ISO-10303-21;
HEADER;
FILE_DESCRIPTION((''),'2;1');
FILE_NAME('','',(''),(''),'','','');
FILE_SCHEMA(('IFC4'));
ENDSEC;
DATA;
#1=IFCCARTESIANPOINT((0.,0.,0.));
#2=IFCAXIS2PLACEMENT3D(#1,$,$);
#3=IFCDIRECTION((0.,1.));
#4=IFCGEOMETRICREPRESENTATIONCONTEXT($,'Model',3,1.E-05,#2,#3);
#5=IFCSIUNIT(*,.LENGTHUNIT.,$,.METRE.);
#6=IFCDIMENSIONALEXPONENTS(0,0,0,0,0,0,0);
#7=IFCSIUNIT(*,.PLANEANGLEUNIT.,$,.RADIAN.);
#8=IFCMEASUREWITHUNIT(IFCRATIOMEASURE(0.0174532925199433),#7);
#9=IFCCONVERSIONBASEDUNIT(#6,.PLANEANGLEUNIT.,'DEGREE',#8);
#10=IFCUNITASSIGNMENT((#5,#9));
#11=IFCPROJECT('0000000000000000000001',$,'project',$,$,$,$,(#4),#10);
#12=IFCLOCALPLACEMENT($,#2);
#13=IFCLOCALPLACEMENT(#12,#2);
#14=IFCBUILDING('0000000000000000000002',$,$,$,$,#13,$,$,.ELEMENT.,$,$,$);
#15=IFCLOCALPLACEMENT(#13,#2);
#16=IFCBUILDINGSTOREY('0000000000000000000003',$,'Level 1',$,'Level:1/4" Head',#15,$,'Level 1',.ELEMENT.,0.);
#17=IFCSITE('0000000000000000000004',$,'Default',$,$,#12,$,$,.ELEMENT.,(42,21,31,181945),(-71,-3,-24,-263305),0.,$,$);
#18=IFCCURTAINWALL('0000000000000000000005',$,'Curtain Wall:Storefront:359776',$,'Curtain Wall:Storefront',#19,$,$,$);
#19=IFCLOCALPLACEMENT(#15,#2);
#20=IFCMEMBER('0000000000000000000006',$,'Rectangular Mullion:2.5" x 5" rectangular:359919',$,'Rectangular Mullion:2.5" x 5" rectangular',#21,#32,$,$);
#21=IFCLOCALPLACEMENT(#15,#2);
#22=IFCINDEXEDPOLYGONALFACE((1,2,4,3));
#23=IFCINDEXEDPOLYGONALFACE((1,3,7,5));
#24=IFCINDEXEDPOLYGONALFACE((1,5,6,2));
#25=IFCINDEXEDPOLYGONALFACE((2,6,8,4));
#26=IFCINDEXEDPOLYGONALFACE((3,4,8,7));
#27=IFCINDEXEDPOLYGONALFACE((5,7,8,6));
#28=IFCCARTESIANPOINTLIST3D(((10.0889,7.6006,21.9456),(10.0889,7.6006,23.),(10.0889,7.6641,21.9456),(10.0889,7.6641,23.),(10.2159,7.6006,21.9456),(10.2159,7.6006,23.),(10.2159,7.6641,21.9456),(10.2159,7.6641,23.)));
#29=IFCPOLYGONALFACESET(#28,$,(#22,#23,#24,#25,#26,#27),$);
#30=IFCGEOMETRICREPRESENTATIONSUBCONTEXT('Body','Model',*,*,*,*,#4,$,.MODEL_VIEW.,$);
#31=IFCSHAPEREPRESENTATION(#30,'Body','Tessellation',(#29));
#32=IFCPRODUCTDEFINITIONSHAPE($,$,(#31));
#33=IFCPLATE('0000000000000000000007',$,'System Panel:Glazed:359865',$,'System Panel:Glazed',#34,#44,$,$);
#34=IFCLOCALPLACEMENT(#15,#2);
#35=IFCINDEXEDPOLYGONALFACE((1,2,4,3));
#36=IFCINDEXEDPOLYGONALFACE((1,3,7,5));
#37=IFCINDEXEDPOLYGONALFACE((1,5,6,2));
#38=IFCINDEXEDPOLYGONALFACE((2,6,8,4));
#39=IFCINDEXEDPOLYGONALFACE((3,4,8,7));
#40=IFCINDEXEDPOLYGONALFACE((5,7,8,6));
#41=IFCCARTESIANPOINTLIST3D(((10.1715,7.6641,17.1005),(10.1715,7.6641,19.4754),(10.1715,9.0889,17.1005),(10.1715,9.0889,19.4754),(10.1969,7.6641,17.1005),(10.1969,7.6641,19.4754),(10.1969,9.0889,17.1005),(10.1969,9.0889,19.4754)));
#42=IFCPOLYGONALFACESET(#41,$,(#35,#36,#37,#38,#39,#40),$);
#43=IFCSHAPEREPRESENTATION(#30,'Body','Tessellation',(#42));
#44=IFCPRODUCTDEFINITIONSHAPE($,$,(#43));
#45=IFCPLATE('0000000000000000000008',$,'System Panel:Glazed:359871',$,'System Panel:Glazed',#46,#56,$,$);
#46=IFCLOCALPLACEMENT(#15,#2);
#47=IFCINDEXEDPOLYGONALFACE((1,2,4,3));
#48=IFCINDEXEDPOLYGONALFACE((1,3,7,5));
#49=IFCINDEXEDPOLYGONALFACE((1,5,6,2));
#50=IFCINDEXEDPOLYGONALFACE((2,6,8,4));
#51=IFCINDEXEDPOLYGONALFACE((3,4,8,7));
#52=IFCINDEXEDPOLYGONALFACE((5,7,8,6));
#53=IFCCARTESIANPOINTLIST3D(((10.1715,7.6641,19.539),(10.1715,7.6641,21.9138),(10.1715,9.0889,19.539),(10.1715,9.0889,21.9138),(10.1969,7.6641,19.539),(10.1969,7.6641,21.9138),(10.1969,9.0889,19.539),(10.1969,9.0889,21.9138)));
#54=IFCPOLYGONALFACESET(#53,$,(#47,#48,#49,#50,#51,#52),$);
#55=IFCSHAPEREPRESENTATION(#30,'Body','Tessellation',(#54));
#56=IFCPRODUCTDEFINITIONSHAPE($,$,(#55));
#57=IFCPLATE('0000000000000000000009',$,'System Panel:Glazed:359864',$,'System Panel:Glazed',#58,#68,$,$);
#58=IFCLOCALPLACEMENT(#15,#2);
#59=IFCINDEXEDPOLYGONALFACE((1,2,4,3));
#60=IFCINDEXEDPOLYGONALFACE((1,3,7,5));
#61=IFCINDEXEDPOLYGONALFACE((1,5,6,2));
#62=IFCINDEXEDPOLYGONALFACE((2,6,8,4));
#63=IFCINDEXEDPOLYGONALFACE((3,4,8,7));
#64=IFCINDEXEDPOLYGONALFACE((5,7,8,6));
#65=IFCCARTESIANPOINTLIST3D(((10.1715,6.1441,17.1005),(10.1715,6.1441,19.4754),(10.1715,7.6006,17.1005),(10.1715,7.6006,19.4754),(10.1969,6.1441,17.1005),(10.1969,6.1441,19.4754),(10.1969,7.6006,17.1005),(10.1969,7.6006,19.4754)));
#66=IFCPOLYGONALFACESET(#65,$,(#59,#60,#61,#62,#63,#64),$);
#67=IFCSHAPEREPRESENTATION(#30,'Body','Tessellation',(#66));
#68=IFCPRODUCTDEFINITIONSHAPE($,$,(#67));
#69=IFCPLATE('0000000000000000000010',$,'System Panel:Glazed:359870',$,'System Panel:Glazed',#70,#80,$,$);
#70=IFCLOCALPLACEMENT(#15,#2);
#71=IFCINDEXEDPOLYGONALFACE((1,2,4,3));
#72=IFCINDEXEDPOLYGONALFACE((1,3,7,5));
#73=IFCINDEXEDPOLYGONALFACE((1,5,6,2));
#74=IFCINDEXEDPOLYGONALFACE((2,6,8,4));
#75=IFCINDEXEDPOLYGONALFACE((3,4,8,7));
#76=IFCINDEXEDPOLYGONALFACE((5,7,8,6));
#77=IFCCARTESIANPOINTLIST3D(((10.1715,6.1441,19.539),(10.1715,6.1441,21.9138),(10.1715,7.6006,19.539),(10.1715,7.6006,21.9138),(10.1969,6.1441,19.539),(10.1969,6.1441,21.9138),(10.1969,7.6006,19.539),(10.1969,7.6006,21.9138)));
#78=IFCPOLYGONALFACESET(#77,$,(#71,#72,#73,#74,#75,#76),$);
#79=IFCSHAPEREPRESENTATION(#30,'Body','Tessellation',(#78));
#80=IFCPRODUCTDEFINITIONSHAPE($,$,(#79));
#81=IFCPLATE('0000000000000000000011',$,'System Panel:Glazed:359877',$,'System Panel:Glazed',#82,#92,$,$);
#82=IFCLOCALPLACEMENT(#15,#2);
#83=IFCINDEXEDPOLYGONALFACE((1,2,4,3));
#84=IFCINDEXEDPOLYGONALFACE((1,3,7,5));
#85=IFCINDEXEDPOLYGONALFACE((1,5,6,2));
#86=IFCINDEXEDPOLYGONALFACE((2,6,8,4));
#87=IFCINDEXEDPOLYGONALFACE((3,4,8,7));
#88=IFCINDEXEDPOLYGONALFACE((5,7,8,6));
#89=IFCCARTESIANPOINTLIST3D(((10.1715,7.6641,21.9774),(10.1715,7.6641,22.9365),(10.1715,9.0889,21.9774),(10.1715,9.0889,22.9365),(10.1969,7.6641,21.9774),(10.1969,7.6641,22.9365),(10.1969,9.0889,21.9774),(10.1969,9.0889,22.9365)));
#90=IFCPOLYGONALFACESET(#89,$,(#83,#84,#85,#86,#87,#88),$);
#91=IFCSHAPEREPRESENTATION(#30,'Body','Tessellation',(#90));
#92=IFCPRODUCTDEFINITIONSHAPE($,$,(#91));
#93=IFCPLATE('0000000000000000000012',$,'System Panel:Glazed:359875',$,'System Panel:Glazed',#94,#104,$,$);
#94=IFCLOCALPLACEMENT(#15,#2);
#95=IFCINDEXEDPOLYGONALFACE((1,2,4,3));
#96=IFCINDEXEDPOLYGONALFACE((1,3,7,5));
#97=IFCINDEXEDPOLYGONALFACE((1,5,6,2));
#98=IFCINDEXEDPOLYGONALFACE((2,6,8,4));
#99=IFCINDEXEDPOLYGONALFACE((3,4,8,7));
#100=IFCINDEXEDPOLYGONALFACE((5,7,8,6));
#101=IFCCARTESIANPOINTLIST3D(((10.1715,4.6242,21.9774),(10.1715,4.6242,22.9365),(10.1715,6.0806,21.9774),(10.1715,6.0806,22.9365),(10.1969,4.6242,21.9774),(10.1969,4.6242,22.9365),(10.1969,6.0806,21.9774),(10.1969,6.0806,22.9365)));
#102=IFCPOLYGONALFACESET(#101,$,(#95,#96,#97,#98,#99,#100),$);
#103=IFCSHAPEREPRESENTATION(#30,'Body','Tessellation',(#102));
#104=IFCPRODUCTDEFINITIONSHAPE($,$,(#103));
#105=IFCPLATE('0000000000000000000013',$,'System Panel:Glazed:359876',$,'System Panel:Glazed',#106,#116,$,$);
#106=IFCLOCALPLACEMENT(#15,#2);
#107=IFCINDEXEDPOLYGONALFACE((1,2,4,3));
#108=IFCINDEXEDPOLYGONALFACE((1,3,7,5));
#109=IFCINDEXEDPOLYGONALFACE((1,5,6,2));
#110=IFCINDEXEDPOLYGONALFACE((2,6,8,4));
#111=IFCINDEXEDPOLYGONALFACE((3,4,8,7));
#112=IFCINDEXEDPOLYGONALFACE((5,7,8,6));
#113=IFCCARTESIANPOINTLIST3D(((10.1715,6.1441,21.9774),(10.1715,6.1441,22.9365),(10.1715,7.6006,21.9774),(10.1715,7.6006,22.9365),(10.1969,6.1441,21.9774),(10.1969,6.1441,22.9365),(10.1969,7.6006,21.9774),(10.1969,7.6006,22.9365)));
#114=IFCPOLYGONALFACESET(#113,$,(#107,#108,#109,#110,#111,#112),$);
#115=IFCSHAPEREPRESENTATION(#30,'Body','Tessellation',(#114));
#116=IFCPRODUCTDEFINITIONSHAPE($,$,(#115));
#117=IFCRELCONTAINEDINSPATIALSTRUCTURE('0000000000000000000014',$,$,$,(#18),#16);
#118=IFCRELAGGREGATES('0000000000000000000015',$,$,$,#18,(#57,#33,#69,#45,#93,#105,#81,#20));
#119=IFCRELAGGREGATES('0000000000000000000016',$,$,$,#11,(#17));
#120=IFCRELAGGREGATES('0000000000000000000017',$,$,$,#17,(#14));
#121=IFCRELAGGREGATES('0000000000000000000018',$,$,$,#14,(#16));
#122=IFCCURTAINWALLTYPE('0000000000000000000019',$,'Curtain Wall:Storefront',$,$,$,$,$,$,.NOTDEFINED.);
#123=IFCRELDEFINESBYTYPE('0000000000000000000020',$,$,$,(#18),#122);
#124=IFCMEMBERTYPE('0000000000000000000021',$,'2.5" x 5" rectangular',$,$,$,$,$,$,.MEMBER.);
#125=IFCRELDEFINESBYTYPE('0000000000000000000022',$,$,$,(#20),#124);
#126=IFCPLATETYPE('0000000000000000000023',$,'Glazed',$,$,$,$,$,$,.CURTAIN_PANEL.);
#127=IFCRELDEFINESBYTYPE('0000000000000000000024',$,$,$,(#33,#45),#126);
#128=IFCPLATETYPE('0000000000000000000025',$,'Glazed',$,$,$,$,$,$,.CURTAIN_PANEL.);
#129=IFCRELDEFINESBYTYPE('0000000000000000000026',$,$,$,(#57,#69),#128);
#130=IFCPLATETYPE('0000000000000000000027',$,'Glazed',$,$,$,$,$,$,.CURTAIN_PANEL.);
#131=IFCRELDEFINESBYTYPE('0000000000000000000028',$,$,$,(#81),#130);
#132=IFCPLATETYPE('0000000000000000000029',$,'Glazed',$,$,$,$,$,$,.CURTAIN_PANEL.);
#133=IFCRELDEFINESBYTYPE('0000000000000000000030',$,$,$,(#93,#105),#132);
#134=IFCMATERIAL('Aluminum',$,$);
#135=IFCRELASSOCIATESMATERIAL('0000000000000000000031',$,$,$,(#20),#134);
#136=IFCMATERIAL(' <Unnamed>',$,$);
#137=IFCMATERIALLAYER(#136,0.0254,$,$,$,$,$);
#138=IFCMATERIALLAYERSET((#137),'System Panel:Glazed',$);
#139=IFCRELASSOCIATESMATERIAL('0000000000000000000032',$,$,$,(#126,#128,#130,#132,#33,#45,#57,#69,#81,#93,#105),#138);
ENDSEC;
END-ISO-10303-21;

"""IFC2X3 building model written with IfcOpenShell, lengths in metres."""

from ifc_helpers import new_model, entity, si_unit, converted_unit, direction, frame, frame_2d, origin, origin_2d_with_axis, place, context, subcontext, project, spatial, rectangle, extrude, source, transform, mapped, material, layer, layer_set, layer_usage, type_object, type_shapes, element, aggregate, save


model = new_model("IFC2X3")

# Units and contexts
model_context = context("Model", 3, precision=1e-05, world=origin(), true_north=direction((0.0, 1.0)))
body_context = subcontext(model_context, "Body", "Model", "MODEL_VIEW")
ifc_project = project(units=[si_unit("LENGTHUNIT", "METRE"), converted_unit("PLANEANGLEUNIT", "DEGREE", entity("IfcRatioMeasure", 0.0174532925199433), si_unit("PLANEANGLEUNIT", "RADIAN"), dimensions=[0, 0, 0, 0, 0, 0, 0])], contexts=[model_context])

# Site, building, storey
site_placement = place(None, origin())
site = spatial("IfcSite", under=ifc_project, at=site_placement, Name="Default", CompositionType="ELEMENT", RefLatitude=(42, 21, 31, 181945), RefLongitude=(-71, -3, -24, -263305), RefElevation=0.0)
building_placement = place(site_placement, origin())
building = spatial("IfcBuilding", under=site, at=building_placement, CompositionType="ELEMENT")
storey_placement = place(building_placement, origin())
storey = spatial("IfcBuildingStorey", under=building, at=storey_placement, Name="Level 1", ObjectType="Level:1/4\" Head", LongName="Level 1", CompositionType="ELEMENT", Elevation=0.0)

# Curtain wall, member, plates
curtain_wall_type = type_object("IfcCurtainWallType", Name="Curtain Wall:Storefront", PredefinedType="NOTDEFINED")
curtain_wall_placement = place(storey_placement, origin())
curtain_wall = element("IfcCurtainWall", 1, at=curtain_wall_placement, inside=storey, type_object=curtain_wall_type, Name="Curtain Wall:Storefront:359776", ObjectType="Curtain Wall:Storefront")
ifc_material_1 = material(Name="Aluminum")
member_type_1 = type_object("IfcMemberType", Name="2.5\" x 5\" rectangular", PredefinedType="MEMBER")
shared_shape_1 = source(origin(), body_context, "Body", "SweptSolid", [
    extrude(rectangle(XDim=0.127, YDim=0.0635, at=origin_2d_with_axis()), frame((0.0, 0.0, -1.0544), z_axis=(0.0, 0.0, 1.0), x_axis=(0.0, -1.0, 0.0)), (0.0, 0.0, 1.0), 1.0544),
])
type_shapes(member_type_1, [shared_shape_1])
member_1_placement = place(storey_placement, frame((10.1524, 7.6324, 21.9456), z_axis=(0.0, 0.0, -1.0), x_axis=(0.0, 1.0, 0.0)))
member_1 = element("IfcMember", 2, at=member_1_placement, type_object=member_type_1, material=ifc_material_1, Name="Rectangular Mullion:2.5\" x 5\" rectangular:359919", ObjectType="Rectangular Mullion:2.5\" x 5\" rectangular", context=body_context, shape_type="MappedRepresentation", body=[
    mapped(shared_shape_1, transform((0.0, 0.0, 0.0), scale=1.0)),
])
ifc_material_2 = material(Name=" <Unnamed>")
ifc_layer = layer(ifc_material_2, 0.0254)
ifc_layer_set = layer_set([ifc_layer], Name="System Panel:Glazed")
ifc_layer_usage_1 = layer_usage(ifc_layer_set, "AXIS3", "POSITIVE", 0.1042)
plate_type_1 = type_object("IfcPlateType", Name="Glazed", PredefinedType="CURTAIN_PANEL", material=ifc_layer_set)
shared_shape_2 = source(origin(), body_context, "Body", "SweptSolid", [
    extrude(rectangle(XDim=0.0254, YDim=1.4248, at=frame_2d((0.0, 0.0), x_axis=(1.0, 0.0))), frame((0.7124, 0.0127, 0.0), z_axis=(0.0, 0.0, 1.0), x_axis=(0.0, 1.0, 0.0)), (0.0, 0.0, 1.0), 2.3749),
])
type_shapes(plate_type_1, [shared_shape_2])
plate_1_placement = place(curtain_wall_placement, frame((10.1969, 7.6641, 17.1005), z_axis=(0.0, 0.0, 1.0), x_axis=(0.0, 1.0, 0.0)))
plate_1 = element("IfcPlate", 3, at=plate_1_placement, type_object=plate_type_1, material=ifc_layer_usage_1, Name="System Panel:Glazed:359865", ObjectType="System Panel:Glazed", context=body_context, shape_type="MappedRepresentation", body=[
    mapped(shared_shape_2, transform((0.0, 0.0, 0.0), scale=1.0)),
])
ifc_layer_usage_2 = layer_usage(ifc_layer_set, "AXIS3", "POSITIVE", 0.1042)
plate_2_placement = place(curtain_wall_placement, frame((10.1969, 7.6641, 19.5389), z_axis=(0.0, 0.0, 1.0), x_axis=(0.0, 1.0, 0.0)))
plate_2 = element("IfcPlate", 4, at=plate_2_placement, type_object=plate_type_1, material=ifc_layer_usage_2, Name="System Panel:Glazed:359871", ObjectType="System Panel:Glazed", context=body_context, shape_type="MappedRepresentation", body=[
    mapped(shared_shape_2, transform((0.0, 0.0, 0.0), scale=1.0)),
])
ifc_layer_usage_3 = layer_usage(ifc_layer_set, "AXIS3", "POSITIVE", 0.1042)
plate_type_2 = type_object("IfcPlateType", Name="Glazed", PredefinedType="CURTAIN_PANEL", material=ifc_layer_set)
shared_shape_3 = source(origin(), body_context, "Body", "SweptSolid", [
    extrude(rectangle(XDim=0.0254, YDim=1.4565, at=origin_2d_with_axis()), frame((0.7282, 0.0127, 0.0), z_axis=(0.0, 0.0, 1.0), x_axis=(0.0, 1.0, 0.0)), (0.0, 0.0, 1.0), 2.3749),
])
type_shapes(plate_type_2, [shared_shape_3])
plate_3_placement = place(curtain_wall_placement, frame((10.1969, 6.1441, 17.1005), z_axis=(0.0, 0.0, 1.0), x_axis=(0.0, 1.0, 0.0)))
plate_3 = element("IfcPlate", 5, at=plate_3_placement, type_object=plate_type_2, material=ifc_layer_usage_3, Name="System Panel:Glazed:359864", ObjectType="System Panel:Glazed", context=body_context, shape_type="MappedRepresentation", body=[
    mapped(shared_shape_3, transform((0.0, 0.0, 0.0), scale=1.0)),
])
ifc_layer_usage_4 = layer_usage(ifc_layer_set, "AXIS3", "POSITIVE", 0.1042)
plate_4_placement = place(curtain_wall_placement, frame((10.1969, 6.1441, 19.5389), z_axis=(0.0, 0.0, 1.0), x_axis=(0.0, 1.0, 0.0)))
plate_4 = element("IfcPlate", 6, at=plate_4_placement, type_object=plate_type_2, material=ifc_layer_usage_4, Name="System Panel:Glazed:359870", ObjectType="System Panel:Glazed", context=body_context, shape_type="MappedRepresentation", body=[
    mapped(shared_shape_3, transform((0.0, 0.0, 0.0), scale=1.0)),
])
ifc_layer_usage_5 = layer_usage(ifc_layer_set, "AXIS3", "POSITIVE", 0.1042)
plate_type_3 = type_object("IfcPlateType", Name="Glazed", PredefinedType="CURTAIN_PANEL", material=ifc_layer_set)
shared_shape_4 = source(origin(), body_context, "Body", "SweptSolid", [
    extrude(rectangle(XDim=0.0254, YDim=1.4248, at=frame_2d((0.0, 0.0), x_axis=(1.0, 0.0))), frame((0.7124, 0.0127, 0.0), z_axis=(0.0, 0.0, 1.0), x_axis=(0.0, 1.0, 0.0)), (0.0, 0.0, 1.0), 0.9592),
])
type_shapes(plate_type_3, [shared_shape_4])
plate_5_placement = place(curtain_wall_placement, frame((10.1969, 7.6641, 21.9774), z_axis=(0.0, 0.0, 1.0), x_axis=(0.0, 1.0, 0.0)))
plate_5 = element("IfcPlate", 7, at=plate_5_placement, type_object=plate_type_3, material=ifc_layer_usage_5, Name="System Panel:Glazed:359877", ObjectType="System Panel:Glazed", context=body_context, shape_type="MappedRepresentation", body=[
    mapped(shared_shape_4, transform((0.0, 0.0, 0.0), scale=1.0)),
])
ifc_layer_usage_6 = layer_usage(ifc_layer_set, "AXIS3", "POSITIVE", 0.1042)
plate_type_4 = type_object("IfcPlateType", Name="Glazed", PredefinedType="CURTAIN_PANEL", material=ifc_layer_set)
shared_shape_5 = source(origin(), body_context, "Body", "SweptSolid", [
    extrude(rectangle(XDim=0.0254, YDim=1.4565, at=origin_2d_with_axis()), frame((0.7282, 0.0127, 0.0), z_axis=(0.0, 0.0, 1.0), x_axis=(0.0, 1.0, 0.0)), (0.0, 0.0, 1.0), 0.9592),
])
type_shapes(plate_type_4, [shared_shape_5])
plate_6_placement = place(curtain_wall_placement, frame((10.1969, 4.6242, 21.9774), z_axis=(0.0, 0.0, 1.0), x_axis=(0.0, 1.0, 0.0)))
plate_6 = element("IfcPlate", 8, at=plate_6_placement, type_object=plate_type_4, material=ifc_layer_usage_6, Name="System Panel:Glazed:359875", ObjectType="System Panel:Glazed", context=body_context, shape_type="MappedRepresentation", body=[
    mapped(shared_shape_5, transform((0.0, 0.0, 0.0), scale=1.0)),
])
ifc_layer_usage_7 = layer_usage(ifc_layer_set, "AXIS3", "POSITIVE", 0.1042)
plate_7_placement = place(curtain_wall_placement, frame((10.1969, 6.1441, 21.9774), z_axis=(0.0, 0.0, 1.0), x_axis=(0.0, 1.0, 0.0)))
plate_7 = element("IfcPlate", 9, at=plate_7_placement, type_object=plate_type_4, material=ifc_layer_usage_7, Name="System Panel:Glazed:359876", ObjectType="System Panel:Glazed", context=body_context, shape_type="MappedRepresentation", body=[
    mapped(shared_shape_5, transform((0.0, 0.0, 0.0), scale=1.0)),
])
aggregate(curtain_wall, [plate_3, plate_1, plate_4, plate_2, plate_6, plate_7, plate_5, member_1])

save(model, "model.ifc")
